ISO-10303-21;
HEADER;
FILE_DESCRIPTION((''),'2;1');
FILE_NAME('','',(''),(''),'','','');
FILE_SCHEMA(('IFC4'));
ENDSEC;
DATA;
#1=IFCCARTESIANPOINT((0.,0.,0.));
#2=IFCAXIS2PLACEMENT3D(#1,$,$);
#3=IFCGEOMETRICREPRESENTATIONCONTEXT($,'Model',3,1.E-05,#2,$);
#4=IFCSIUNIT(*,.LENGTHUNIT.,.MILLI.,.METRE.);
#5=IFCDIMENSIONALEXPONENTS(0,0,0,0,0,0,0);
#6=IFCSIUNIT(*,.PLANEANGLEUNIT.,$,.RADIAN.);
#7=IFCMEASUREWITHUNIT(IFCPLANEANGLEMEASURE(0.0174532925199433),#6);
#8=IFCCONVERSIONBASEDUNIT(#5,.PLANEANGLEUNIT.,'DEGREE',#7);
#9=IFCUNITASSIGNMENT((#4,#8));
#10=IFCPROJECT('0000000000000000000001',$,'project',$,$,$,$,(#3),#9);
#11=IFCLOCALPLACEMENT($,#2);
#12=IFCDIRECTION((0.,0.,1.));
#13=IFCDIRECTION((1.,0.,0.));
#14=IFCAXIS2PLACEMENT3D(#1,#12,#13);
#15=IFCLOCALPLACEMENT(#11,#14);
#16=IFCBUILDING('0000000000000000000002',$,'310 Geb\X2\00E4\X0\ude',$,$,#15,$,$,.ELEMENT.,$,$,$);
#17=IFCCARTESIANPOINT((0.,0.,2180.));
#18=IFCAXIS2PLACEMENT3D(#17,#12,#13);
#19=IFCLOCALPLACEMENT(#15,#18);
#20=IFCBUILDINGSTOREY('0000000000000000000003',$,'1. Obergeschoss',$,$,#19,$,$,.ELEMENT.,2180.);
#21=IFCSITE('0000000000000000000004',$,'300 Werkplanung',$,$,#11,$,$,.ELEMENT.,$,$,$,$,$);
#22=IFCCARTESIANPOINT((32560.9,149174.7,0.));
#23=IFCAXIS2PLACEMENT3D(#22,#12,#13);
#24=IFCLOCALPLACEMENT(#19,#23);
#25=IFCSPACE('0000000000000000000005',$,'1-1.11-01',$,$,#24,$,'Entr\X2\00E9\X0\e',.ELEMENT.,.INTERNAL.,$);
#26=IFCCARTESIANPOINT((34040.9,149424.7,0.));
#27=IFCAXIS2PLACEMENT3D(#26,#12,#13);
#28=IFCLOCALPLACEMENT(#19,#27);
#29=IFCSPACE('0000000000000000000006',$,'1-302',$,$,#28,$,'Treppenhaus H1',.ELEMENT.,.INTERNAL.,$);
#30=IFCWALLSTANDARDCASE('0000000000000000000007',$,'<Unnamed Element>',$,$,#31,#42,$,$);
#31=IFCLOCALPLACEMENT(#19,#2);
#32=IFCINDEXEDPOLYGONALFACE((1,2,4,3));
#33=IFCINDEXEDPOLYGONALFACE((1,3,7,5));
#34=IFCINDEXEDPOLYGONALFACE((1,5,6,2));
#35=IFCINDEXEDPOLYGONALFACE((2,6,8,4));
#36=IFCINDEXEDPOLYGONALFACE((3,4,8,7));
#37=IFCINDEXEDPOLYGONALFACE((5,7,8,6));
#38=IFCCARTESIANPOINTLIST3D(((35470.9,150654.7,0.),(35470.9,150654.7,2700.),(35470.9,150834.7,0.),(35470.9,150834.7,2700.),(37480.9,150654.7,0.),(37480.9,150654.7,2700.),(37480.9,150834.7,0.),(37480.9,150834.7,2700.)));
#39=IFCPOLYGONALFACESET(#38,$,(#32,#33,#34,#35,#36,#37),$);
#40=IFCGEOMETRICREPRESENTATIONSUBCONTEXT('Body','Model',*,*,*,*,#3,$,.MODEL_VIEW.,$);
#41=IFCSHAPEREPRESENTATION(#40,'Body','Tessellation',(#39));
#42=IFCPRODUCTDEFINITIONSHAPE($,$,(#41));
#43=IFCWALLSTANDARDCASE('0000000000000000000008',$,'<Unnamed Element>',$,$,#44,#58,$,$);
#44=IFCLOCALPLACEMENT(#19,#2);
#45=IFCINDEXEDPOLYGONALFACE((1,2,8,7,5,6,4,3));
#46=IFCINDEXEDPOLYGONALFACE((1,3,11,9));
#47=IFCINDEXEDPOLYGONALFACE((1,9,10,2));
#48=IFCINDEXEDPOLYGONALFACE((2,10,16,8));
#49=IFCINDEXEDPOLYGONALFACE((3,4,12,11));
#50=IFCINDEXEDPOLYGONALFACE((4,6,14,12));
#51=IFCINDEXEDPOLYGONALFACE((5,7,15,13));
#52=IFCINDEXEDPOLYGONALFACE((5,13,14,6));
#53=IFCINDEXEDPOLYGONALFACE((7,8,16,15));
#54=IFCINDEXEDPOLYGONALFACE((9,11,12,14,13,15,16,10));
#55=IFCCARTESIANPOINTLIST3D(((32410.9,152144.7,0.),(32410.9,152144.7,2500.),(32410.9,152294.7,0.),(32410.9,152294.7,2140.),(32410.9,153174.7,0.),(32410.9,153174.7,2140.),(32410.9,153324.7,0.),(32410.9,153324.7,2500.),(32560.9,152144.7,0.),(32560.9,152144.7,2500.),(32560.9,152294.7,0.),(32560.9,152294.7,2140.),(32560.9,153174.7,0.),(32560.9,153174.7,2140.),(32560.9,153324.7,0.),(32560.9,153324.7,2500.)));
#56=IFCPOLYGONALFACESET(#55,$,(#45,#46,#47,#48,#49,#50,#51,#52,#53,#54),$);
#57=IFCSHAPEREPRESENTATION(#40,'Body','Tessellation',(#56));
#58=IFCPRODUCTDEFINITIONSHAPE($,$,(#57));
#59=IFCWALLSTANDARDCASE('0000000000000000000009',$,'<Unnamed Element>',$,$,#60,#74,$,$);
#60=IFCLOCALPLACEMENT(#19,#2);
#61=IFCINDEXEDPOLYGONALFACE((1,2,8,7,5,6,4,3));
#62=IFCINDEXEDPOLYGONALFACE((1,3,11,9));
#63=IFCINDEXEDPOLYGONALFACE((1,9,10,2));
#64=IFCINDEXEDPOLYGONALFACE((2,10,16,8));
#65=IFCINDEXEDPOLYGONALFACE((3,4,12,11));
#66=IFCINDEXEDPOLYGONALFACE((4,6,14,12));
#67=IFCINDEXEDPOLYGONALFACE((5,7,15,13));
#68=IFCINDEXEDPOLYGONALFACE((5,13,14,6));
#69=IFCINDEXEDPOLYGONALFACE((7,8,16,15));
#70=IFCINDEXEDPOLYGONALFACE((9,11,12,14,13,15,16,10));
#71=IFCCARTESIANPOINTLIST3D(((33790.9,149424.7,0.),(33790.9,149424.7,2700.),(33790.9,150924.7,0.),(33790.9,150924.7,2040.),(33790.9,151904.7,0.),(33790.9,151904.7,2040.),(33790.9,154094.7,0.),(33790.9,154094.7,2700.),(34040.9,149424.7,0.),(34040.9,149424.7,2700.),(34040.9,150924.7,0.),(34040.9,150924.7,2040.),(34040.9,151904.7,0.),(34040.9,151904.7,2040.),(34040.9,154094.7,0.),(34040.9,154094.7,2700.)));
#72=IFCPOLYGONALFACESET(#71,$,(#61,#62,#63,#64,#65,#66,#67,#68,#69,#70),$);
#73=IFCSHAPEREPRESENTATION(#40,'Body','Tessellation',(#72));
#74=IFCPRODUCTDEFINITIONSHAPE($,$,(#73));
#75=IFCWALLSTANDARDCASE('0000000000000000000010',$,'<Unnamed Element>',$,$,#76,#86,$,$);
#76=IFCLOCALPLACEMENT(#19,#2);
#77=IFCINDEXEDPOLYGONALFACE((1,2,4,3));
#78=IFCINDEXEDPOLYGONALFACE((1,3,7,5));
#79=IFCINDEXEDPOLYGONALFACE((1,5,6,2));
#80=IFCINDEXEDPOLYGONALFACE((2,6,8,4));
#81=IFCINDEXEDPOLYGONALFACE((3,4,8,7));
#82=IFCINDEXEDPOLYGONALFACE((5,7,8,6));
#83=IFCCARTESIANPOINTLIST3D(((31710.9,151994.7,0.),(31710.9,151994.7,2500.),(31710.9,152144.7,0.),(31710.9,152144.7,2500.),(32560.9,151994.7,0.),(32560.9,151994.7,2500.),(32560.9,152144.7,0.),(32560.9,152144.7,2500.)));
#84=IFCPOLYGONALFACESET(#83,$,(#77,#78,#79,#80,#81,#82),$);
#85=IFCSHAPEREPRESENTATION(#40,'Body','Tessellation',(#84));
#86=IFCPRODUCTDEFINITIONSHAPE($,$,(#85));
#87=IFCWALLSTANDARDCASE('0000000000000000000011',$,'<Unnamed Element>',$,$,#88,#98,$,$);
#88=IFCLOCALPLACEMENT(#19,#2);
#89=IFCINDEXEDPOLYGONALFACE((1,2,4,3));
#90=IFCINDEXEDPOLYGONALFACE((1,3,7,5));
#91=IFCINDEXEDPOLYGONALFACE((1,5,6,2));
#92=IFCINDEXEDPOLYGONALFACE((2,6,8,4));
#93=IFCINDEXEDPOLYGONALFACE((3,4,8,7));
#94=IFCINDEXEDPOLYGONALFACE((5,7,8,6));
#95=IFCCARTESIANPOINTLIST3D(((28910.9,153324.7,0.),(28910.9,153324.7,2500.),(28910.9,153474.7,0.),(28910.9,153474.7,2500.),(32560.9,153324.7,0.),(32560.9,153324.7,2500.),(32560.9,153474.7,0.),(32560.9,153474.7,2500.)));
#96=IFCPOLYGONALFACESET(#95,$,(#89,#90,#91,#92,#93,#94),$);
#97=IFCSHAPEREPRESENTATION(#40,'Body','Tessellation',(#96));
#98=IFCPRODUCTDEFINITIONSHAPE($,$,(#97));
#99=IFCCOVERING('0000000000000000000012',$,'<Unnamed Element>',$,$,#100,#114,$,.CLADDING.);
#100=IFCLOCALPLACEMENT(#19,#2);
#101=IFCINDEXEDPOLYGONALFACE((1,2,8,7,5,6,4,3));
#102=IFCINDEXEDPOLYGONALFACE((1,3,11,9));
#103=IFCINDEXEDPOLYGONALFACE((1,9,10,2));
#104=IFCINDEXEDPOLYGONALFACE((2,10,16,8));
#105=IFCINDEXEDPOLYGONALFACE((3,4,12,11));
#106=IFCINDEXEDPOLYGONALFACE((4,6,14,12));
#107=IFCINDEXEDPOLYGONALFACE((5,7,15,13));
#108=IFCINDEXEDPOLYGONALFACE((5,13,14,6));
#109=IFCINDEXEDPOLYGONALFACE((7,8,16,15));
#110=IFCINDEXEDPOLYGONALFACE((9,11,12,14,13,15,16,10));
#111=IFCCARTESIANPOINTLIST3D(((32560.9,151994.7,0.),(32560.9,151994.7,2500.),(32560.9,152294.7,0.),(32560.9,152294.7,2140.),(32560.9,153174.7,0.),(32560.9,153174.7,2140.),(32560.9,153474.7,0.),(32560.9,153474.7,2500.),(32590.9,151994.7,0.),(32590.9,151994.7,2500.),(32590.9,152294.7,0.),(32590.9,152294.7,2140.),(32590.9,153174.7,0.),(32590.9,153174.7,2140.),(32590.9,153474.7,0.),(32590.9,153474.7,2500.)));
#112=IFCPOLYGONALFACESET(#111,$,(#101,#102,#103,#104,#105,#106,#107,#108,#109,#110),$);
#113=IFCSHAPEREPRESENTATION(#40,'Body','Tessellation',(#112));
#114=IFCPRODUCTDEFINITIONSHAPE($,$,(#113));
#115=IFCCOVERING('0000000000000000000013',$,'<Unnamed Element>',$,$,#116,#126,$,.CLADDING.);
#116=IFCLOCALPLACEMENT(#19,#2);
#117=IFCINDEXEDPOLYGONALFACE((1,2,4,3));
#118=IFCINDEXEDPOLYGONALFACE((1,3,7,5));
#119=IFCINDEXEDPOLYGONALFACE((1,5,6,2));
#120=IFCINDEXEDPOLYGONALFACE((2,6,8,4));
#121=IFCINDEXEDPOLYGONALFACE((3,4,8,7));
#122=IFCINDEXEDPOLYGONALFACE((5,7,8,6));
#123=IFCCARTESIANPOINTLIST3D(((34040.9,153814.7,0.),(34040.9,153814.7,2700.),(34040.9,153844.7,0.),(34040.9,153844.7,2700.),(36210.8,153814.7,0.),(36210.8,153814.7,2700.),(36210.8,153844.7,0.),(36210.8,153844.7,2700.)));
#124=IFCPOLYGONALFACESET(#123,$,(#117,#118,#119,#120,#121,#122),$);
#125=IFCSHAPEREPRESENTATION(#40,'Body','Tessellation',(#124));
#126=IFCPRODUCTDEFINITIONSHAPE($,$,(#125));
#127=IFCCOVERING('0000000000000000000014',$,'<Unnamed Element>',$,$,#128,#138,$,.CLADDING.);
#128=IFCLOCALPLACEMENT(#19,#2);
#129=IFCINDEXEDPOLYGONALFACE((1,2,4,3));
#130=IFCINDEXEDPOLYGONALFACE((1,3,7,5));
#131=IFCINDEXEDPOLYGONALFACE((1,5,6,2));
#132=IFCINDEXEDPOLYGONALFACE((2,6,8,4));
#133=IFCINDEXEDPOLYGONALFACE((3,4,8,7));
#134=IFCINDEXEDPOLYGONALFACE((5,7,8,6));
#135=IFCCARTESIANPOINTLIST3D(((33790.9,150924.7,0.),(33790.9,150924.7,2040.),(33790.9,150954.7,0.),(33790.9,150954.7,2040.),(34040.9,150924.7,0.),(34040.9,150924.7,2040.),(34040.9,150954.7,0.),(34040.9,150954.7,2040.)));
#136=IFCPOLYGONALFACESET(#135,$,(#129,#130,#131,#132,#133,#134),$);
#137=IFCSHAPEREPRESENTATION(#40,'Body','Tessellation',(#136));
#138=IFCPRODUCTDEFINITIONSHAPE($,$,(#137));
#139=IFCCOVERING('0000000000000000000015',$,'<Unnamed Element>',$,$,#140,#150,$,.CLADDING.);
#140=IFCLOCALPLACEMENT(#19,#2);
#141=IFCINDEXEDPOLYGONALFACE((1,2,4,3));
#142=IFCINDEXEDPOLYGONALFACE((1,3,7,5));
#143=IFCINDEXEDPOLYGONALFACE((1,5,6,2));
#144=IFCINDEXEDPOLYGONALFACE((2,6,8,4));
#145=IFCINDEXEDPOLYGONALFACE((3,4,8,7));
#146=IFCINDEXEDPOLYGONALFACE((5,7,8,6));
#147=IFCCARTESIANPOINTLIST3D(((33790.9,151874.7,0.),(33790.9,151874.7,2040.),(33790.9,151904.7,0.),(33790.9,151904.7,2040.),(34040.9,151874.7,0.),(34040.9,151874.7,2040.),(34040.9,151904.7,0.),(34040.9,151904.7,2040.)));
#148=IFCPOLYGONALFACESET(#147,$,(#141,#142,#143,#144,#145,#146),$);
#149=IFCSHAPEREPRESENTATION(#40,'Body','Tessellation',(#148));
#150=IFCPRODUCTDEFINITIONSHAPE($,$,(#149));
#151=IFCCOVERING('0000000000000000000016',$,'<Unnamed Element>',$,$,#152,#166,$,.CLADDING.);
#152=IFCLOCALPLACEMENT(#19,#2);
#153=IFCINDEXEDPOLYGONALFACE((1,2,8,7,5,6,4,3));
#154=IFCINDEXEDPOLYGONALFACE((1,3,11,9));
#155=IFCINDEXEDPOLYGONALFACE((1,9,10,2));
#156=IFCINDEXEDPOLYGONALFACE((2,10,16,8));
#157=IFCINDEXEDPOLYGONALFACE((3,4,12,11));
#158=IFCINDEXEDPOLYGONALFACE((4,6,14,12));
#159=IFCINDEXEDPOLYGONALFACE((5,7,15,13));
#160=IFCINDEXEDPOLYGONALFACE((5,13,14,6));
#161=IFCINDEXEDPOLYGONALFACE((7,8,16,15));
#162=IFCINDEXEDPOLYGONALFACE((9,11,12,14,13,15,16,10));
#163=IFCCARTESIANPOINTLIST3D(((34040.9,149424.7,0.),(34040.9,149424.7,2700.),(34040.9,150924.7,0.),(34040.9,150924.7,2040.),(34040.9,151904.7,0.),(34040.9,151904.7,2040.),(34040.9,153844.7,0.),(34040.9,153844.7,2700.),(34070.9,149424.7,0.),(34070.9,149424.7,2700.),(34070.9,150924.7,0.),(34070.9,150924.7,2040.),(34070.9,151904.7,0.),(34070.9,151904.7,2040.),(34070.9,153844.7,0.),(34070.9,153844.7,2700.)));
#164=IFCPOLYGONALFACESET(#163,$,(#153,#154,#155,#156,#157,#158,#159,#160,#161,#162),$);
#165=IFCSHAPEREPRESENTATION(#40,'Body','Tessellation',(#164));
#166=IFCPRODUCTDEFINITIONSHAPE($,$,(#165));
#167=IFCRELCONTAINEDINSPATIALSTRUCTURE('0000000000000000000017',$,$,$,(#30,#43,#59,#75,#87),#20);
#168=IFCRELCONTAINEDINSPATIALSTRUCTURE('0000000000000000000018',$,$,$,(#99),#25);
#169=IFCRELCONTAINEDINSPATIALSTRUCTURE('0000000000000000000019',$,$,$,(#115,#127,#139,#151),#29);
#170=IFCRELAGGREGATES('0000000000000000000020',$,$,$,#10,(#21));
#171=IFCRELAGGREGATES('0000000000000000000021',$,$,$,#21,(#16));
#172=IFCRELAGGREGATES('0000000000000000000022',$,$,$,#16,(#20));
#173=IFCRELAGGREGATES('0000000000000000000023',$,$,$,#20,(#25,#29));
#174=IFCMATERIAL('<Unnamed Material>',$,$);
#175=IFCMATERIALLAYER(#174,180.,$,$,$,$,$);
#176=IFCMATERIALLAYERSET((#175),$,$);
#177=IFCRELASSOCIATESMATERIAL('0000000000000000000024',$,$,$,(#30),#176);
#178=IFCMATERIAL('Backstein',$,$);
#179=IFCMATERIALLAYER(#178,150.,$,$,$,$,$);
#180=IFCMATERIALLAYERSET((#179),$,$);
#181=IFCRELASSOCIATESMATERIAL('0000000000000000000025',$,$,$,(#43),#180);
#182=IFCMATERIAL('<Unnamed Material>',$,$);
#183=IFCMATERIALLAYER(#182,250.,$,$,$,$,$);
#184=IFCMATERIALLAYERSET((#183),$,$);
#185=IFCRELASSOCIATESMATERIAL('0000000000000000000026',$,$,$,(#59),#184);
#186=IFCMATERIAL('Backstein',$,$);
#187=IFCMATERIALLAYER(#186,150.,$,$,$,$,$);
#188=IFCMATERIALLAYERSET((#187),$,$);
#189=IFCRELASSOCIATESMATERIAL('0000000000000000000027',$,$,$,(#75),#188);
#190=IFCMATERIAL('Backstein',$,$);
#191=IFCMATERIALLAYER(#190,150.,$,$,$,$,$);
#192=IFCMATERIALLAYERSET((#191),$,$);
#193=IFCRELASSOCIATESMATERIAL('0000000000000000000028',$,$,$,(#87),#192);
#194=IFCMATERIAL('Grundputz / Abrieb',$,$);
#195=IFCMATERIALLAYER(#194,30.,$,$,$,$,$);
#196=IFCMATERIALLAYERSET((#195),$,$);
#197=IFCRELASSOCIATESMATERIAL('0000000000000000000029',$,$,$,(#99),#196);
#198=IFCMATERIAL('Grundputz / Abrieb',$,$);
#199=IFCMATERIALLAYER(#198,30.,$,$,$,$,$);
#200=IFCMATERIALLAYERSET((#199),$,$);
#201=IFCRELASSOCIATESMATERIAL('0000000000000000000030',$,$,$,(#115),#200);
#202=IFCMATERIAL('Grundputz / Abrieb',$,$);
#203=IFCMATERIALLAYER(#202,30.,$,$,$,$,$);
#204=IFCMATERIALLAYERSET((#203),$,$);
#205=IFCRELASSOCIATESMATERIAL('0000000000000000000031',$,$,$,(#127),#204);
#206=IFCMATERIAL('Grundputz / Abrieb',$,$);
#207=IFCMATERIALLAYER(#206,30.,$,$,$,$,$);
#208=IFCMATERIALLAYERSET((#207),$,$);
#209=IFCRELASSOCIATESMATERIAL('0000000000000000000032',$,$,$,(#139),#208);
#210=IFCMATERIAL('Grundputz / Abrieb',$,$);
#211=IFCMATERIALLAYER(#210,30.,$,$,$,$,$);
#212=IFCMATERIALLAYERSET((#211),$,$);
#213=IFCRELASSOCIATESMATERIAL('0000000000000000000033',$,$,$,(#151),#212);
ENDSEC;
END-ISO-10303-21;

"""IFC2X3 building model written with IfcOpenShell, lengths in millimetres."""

from ifc_helpers import new_model, entity, si_unit, converted_unit, frame, frame_2d, origin, origin_with_axes, place, context, subcontext, project, spatial, polyline, rectangle, outline, extrude, material, layer, layer_set, layer_usage, element, save


model = new_model("IFC2X3")

# Units and contexts
model_context = context("Model", 3, precision=1e-05, world=origin())
body_context = subcontext(model_context, "Body", "Model", "MODEL_VIEW")
ifc_project = project(units=[si_unit("LENGTHUNIT", "METRE", prefix="MILLI"), converted_unit("PLANEANGLEUNIT", "DEGREE", entity("IfcPlaneAngleMeasure", 0.0174532925199433), si_unit("PLANEANGLEUNIT", "RADIAN"), dimensions=[0, 0, 0, 0, 0, 0, 0])], contexts=[model_context])

# Site, building, storey
site_placement = place(None, origin())
site = spatial("IfcSite", under=ifc_project, at=site_placement, Name="300 Werkplanung", CompositionType="ELEMENT")
building_placement = place(site_placement, origin_with_axes())
building = spatial("IfcBuilding", under=site, at=building_placement, Name="310 Gebäude", CompositionType="ELEMENT")
storey_placement = place(building_placement, frame((0.0, 0.0, 2180.0), z_axis=(0.0, 0.0, 1.0), x_axis=(1.0, 0.0, 0.0)))
storey = spatial("IfcBuildingStorey", under=building, at=storey_placement, Name="1. Obergeschoss", CompositionType="ELEMENT", Elevation=2180.0)

# Wall
ifc_material_1 = material(Name="<Unnamed Material>")
ifc_layer_1 = layer(ifc_material_1, 180.0)
ifc_layer_set_1 = layer_set([ifc_layer_1])
ifc_layer_usage_1 = layer_usage(ifc_layer_set_1, "AXIS2", "POSITIVE", -180.0)
wall_1_placement = place(storey_placement, frame((35470.9, 150654.7, 0.0), z_axis=(0.0, 0.0, 1.0), x_axis=(1.0, 0.0, 0.0)))
element("IfcWallStandardCase", 1, at=wall_1_placement, inside=storey, material=ifc_layer_usage_1, Name="<Unnamed Element>", context=body_context, shape_type="SweptSolid", body=[
    extrude(rectangle(XDim=2010.0, YDim=180.0, at=frame_2d((1005.0, 90.0), x_axis=(1.0, 0.0))), origin_with_axes(), (0.0, 0.0, 1.0), 2700.0),
])

# Walls, openings
ifc_material_2 = material(Name="Backstein")
ifc_layer_2 = layer(ifc_material_2, 150.0)
ifc_layer_set_2 = layer_set([ifc_layer_2])
ifc_layer_usage_2 = layer_usage(ifc_layer_set_2, "AXIS2", "POSITIVE", 0.0)
wall_2_placement = place(storey_placement, frame((32560.9, 152144.7, 0.0), z_axis=(0.0, 0.0, 1.0), x_axis=(0.0, 1.0, 0.0)))
wall_2 = element("IfcWallStandardCase", 2, at=wall_2_placement, inside=storey, material=ifc_layer_usage_2, Name="<Unnamed Element>", context=body_context, shape_type="SweptSolid", body=[
    extrude(rectangle(XDim=1180.0, YDim=150.0, at=frame_2d((590.0, 75.0), x_axis=(1.0, 0.0))), origin_with_axes(), (0.0, 0.0, 1.0), 2500.0),
])
opening_1_placement = place(wall_2_placement, frame((150.0, 0.0, 0.0), z_axis=(0.0, 1.0, 0.0), x_axis=(0.0, 0.0, 1.0)))
element("IfcOpeningElement", 3, at=opening_1_placement, cuts=wall_2, ObjectType="Opening", context=body_context, shape_type="SweptSolid", body=[
    extrude(rectangle(XDim=2140.0, YDim=880.0, at=frame_2d((1070.0, 440.0), x_axis=(1.0, 0.0))), origin_with_axes(), (0.0, 0.0, 1.0), 150.0),
])
ifc_material_3 = material(Name="<Unnamed Material>")
ifc_layer_3 = layer(ifc_material_3, 250.0)
ifc_layer_set_3 = layer_set([ifc_layer_3])
ifc_layer_usage_3 = layer_usage(ifc_layer_set_3, "AXIS2", "POSITIVE", -250.0)
wall_3_placement = place(storey_placement, frame((33790.9, 154094.7, 0.0), z_axis=(0.0, 0.0, 1.0), x_axis=(0.0, -1.0, 0.0)))
wall_3 = element("IfcWallStandardCase", 4, at=wall_3_placement, inside=storey, material=ifc_layer_usage_3, Name="<Unnamed Element>", context=body_context, shape_type="SweptSolid", body=[
    extrude(rectangle(XDim=4670.0, YDim=250.0, at=frame_2d((2335.0, 125.0), x_axis=(1.0, 0.0))), origin_with_axes(), (0.0, 0.0, 1.0), 2700.0),
])
opening_2_placement = place(wall_3_placement, frame((2190.0, 0.0, 0.0), z_axis=(0.0, 1.0, 0.0), x_axis=(0.0, 0.0, 1.0)))
element("IfcOpeningElement", 5, at=opening_2_placement, cuts=wall_3, ObjectType="Opening", context=body_context, shape_type="SweptSolid", body=[
    extrude(rectangle(XDim=2040.0, YDim=980.0, at=frame_2d((1020.0, 490.0), x_axis=(1.0, 0.0))), origin_with_axes(), (0.0, 0.0, 1.0), 250.0),
])

# Walls
ifc_material_4 = material(Name="Backstein")
ifc_layer_4 = layer(ifc_material_4, 150.0)
ifc_layer_set_4 = layer_set([ifc_layer_4])
ifc_layer_usage_4 = layer_usage(ifc_layer_set_4, "AXIS2", "POSITIVE", 0.0)
wall_4_placement = place(storey_placement, frame((32560.9, 152144.7, 0.0), z_axis=(0.0, 0.0, 1.0), x_axis=(-1.0, 0.0, 0.0)))
element("IfcWallStandardCase", 6, at=wall_4_placement, inside=storey, material=ifc_layer_usage_4, Name="<Unnamed Element>", context=body_context, shape_type="SweptSolid", body=[
    extrude(rectangle(XDim=850.0, YDim=150.0, at=frame_2d((425.0, 75.0), x_axis=(1.0, 0.0))), origin_with_axes(), (0.0, 0.0, 1.0), 2500.0),
])
ifc_material_5 = material(Name="Backstein")
ifc_layer_5 = layer(ifc_material_5, 150.0)
ifc_layer_set_5 = layer_set([ifc_layer_5])
ifc_layer_usage_5 = layer_usage(ifc_layer_set_5, "AXIS2", "POSITIVE", 0.0)
wall_5_placement = place(storey_placement, frame((32560.9, 153474.7, 0.0), z_axis=(0.0, 0.0, 1.0), x_axis=(-1.0, 0.0, 0.0)))
element("IfcWallStandardCase", 7, at=wall_5_placement, inside=storey, material=ifc_layer_usage_5, Name="<Unnamed Element>", context=body_context, shape_type="SweptSolid", body=[
    extrude(rectangle(XDim=3650.0, YDim=150.0, at=frame_2d((1825.0, 75.0), x_axis=(1.0, 0.0))), origin_with_axes(), (0.0, 0.0, 1.0), 2500.0),
])

# Shared definitions
space_1_placement = place(storey_placement, frame((32560.9, 149174.7, 0.0), z_axis=(0.0, 0.0, 1.0), x_axis=(1.0, 0.0, 0.0)))
space_1 = spatial("IfcSpace", under=storey, at=space_1_placement, Name="1-1.11-01", LongName="Entrée", CompositionType="ELEMENT", InteriorOrExteriorSpace="INTERNAL")

# Covering
ifc_material_6 = material(Name="Grundputz / Abrieb")
ifc_layer_6 = layer(ifc_material_6, 30.0)
ifc_layer_set_6 = layer_set([ifc_layer_6])
ifc_layer_usage_6 = layer_usage(ifc_layer_set_6, "AXIS3", "POSITIVE", 0.0)
covering_1_placement = place(space_1_placement, frame((0.0, 4300.0, 0.0), z_axis=(0.0, 0.0, 1.0), x_axis=(0.0, -1.0, 0.0)))
element("IfcCovering", 8, at=covering_1_placement, inside=space_1, material=ifc_layer_usage_6, Name="<Unnamed Element>", PredefinedType="CLADDING", context=body_context, shape_type="SweptSolid", body=[
    extrude(outline(polyline([(0.0, -2500.0), (0.0, 0.0), (300.0, 0.0), (300.0, -2140.0), (1180.0, -2140.0), (1180.0, 0.0), (1480.0, 0.0), (1480.0, -2500.0), (0.0, -2500.0)])), frame((0.0, 0.0, 0.0), z_axis=(0.0, 1.0, 0.0), x_axis=(1.0, 0.0, 0.0)), (0.0, 0.0, 1.0), 30.0),
])

# Shared definitions
space_2_placement = place(storey_placement, frame((34040.9, 149424.7, 0.0), z_axis=(0.0, 0.0, 1.0), x_axis=(1.0, 0.0, 0.0)))
space_2 = spatial("IfcSpace", under=storey, at=space_2_placement, Name="1-302", LongName="Treppenhaus H1", CompositionType="ELEMENT", InteriorOrExteriorSpace="INTERNAL")

# Coverings
ifc_material_7 = material(Name="Grundputz / Abrieb")
ifc_layer_7 = layer(ifc_material_7, 30.0)
ifc_layer_set_7 = layer_set([ifc_layer_7])
ifc_layer_usage_7 = layer_usage(ifc_layer_set_7, "AXIS3", "POSITIVE", 0.0)
covering_2_placement = place(space_2_placement, frame((2169.9, 4420.0, 0.0), z_axis=(0.0, 0.0, 1.0), x_axis=(-1.0, 0.0, 0.0)))
element("IfcCovering", 9, at=covering_2_placement, inside=space_2, material=ifc_layer_usage_7, Name="<Unnamed Element>", PredefinedType="CLADDING", context=body_context, shape_type="SweptSolid", body=[
    extrude(rectangle(XDim=2700.0, YDim=2169.9, at=frame_2d((-1084.9, 1350.0), x_axis=(0.0, 1.0))), frame((2169.9, 0.0, 2700.0), z_axis=(0.0, 1.0, 0.0), x_axis=(1.0, 0.0, 0.0)), (0.0, 0.0, 1.0), 30.0),
])
ifc_material_8 = material(Name="Grundputz / Abrieb")
ifc_layer_8 = layer(ifc_material_8, 30.0)
ifc_layer_set_8 = layer_set([ifc_layer_8])
ifc_layer_usage_8 = layer_usage(ifc_layer_set_8, "AXIS3", "POSITIVE", 0.0)
covering_3_placement = place(space_2_placement, frame((-250.0, 1500.0, 0.0), z_axis=(0.0, 0.0, 1.0), x_axis=(1.0, 0.0, 0.0)))
element("IfcCovering", 10, at=covering_3_placement, inside=space_2, material=ifc_layer_usage_8, Name="<Unnamed Element>", PredefinedType="CLADDING", context=body_context, shape_type="SweptSolid", body=[
    extrude(rectangle(XDim=2040.0, YDim=250.0, at=frame_2d((-125.0, 1020.0), x_axis=(0.0, 1.0))), frame((250.0, 0.0, 2040.0), z_axis=(0.0, 1.0, 0.0), x_axis=(1.0, 0.0, 0.0)), (0.0, 0.0, 1.0), 30.0),
])
ifc_material_9 = material(Name="Grundputz / Abrieb")
ifc_layer_9 = layer(ifc_material_9, 30.0)
ifc_layer_set_9 = layer_set([ifc_layer_9])
ifc_layer_usage_9 = layer_usage(ifc_layer_set_9, "AXIS3", "POSITIVE", 0.0)
covering_4_placement = place(space_2_placement, frame((0.0, 2480.0, 0.0), z_axis=(0.0, 0.0, 1.0), x_axis=(-1.0, 0.0, 0.0)))
element("IfcCovering", 11, at=covering_4_placement, inside=space_2, material=ifc_layer_usage_9, Name="<Unnamed Element>", PredefinedType="CLADDING", context=body_context, shape_type="SweptSolid", body=[
    extrude(rectangle(XDim=2040.0, YDim=250.0, at=frame_2d((-125.0, 1020.0), x_axis=(0.0, 1.0))), frame((250.0, 0.0, 2040.0), z_axis=(0.0, 1.0, 0.0), x_axis=(1.0, 0.0, 0.0)), (0.0, 0.0, 1.0), 30.0),
])
ifc_material_10 = material(Name="Grundputz / Abrieb")
ifc_layer_10 = layer(ifc_material_10, 30.0)
ifc_layer_set_10 = layer_set([ifc_layer_10])
ifc_layer_usage_10 = layer_usage(ifc_layer_set_10, "AXIS3", "POSITIVE", 0.0)
covering_5_placement = place(space_2_placement, frame((0.0, 4420.0, 0.0), z_axis=(0.0, 0.0, 1.0), x_axis=(0.0, -1.0, 0.0)))
element("IfcCovering", 12, at=covering_5_placement, inside=space_2, material=ifc_layer_usage_10, Name="<Unnamed Element>", PredefinedType="CLADDING", context=body_context, shape_type="SweptSolid", body=[
    extrude(outline(polyline([(4420.0, 0.0), (4420.0, -2700.0), (0.0, -2700.0), (0.0, 0.0), (1940.0, 0.0), (1940.0, -2040.0), (2920.0, -2040.0), (2920.0, 0.0), (4420.0, 0.0)])), frame((0.0, 0.0, 0.0), z_axis=(0.0, 1.0, 0.0), x_axis=(1.0, 0.0, 0.0)), (0.0, 0.0, 1.0), 30.0),
])

save(model, "model.ifc")
